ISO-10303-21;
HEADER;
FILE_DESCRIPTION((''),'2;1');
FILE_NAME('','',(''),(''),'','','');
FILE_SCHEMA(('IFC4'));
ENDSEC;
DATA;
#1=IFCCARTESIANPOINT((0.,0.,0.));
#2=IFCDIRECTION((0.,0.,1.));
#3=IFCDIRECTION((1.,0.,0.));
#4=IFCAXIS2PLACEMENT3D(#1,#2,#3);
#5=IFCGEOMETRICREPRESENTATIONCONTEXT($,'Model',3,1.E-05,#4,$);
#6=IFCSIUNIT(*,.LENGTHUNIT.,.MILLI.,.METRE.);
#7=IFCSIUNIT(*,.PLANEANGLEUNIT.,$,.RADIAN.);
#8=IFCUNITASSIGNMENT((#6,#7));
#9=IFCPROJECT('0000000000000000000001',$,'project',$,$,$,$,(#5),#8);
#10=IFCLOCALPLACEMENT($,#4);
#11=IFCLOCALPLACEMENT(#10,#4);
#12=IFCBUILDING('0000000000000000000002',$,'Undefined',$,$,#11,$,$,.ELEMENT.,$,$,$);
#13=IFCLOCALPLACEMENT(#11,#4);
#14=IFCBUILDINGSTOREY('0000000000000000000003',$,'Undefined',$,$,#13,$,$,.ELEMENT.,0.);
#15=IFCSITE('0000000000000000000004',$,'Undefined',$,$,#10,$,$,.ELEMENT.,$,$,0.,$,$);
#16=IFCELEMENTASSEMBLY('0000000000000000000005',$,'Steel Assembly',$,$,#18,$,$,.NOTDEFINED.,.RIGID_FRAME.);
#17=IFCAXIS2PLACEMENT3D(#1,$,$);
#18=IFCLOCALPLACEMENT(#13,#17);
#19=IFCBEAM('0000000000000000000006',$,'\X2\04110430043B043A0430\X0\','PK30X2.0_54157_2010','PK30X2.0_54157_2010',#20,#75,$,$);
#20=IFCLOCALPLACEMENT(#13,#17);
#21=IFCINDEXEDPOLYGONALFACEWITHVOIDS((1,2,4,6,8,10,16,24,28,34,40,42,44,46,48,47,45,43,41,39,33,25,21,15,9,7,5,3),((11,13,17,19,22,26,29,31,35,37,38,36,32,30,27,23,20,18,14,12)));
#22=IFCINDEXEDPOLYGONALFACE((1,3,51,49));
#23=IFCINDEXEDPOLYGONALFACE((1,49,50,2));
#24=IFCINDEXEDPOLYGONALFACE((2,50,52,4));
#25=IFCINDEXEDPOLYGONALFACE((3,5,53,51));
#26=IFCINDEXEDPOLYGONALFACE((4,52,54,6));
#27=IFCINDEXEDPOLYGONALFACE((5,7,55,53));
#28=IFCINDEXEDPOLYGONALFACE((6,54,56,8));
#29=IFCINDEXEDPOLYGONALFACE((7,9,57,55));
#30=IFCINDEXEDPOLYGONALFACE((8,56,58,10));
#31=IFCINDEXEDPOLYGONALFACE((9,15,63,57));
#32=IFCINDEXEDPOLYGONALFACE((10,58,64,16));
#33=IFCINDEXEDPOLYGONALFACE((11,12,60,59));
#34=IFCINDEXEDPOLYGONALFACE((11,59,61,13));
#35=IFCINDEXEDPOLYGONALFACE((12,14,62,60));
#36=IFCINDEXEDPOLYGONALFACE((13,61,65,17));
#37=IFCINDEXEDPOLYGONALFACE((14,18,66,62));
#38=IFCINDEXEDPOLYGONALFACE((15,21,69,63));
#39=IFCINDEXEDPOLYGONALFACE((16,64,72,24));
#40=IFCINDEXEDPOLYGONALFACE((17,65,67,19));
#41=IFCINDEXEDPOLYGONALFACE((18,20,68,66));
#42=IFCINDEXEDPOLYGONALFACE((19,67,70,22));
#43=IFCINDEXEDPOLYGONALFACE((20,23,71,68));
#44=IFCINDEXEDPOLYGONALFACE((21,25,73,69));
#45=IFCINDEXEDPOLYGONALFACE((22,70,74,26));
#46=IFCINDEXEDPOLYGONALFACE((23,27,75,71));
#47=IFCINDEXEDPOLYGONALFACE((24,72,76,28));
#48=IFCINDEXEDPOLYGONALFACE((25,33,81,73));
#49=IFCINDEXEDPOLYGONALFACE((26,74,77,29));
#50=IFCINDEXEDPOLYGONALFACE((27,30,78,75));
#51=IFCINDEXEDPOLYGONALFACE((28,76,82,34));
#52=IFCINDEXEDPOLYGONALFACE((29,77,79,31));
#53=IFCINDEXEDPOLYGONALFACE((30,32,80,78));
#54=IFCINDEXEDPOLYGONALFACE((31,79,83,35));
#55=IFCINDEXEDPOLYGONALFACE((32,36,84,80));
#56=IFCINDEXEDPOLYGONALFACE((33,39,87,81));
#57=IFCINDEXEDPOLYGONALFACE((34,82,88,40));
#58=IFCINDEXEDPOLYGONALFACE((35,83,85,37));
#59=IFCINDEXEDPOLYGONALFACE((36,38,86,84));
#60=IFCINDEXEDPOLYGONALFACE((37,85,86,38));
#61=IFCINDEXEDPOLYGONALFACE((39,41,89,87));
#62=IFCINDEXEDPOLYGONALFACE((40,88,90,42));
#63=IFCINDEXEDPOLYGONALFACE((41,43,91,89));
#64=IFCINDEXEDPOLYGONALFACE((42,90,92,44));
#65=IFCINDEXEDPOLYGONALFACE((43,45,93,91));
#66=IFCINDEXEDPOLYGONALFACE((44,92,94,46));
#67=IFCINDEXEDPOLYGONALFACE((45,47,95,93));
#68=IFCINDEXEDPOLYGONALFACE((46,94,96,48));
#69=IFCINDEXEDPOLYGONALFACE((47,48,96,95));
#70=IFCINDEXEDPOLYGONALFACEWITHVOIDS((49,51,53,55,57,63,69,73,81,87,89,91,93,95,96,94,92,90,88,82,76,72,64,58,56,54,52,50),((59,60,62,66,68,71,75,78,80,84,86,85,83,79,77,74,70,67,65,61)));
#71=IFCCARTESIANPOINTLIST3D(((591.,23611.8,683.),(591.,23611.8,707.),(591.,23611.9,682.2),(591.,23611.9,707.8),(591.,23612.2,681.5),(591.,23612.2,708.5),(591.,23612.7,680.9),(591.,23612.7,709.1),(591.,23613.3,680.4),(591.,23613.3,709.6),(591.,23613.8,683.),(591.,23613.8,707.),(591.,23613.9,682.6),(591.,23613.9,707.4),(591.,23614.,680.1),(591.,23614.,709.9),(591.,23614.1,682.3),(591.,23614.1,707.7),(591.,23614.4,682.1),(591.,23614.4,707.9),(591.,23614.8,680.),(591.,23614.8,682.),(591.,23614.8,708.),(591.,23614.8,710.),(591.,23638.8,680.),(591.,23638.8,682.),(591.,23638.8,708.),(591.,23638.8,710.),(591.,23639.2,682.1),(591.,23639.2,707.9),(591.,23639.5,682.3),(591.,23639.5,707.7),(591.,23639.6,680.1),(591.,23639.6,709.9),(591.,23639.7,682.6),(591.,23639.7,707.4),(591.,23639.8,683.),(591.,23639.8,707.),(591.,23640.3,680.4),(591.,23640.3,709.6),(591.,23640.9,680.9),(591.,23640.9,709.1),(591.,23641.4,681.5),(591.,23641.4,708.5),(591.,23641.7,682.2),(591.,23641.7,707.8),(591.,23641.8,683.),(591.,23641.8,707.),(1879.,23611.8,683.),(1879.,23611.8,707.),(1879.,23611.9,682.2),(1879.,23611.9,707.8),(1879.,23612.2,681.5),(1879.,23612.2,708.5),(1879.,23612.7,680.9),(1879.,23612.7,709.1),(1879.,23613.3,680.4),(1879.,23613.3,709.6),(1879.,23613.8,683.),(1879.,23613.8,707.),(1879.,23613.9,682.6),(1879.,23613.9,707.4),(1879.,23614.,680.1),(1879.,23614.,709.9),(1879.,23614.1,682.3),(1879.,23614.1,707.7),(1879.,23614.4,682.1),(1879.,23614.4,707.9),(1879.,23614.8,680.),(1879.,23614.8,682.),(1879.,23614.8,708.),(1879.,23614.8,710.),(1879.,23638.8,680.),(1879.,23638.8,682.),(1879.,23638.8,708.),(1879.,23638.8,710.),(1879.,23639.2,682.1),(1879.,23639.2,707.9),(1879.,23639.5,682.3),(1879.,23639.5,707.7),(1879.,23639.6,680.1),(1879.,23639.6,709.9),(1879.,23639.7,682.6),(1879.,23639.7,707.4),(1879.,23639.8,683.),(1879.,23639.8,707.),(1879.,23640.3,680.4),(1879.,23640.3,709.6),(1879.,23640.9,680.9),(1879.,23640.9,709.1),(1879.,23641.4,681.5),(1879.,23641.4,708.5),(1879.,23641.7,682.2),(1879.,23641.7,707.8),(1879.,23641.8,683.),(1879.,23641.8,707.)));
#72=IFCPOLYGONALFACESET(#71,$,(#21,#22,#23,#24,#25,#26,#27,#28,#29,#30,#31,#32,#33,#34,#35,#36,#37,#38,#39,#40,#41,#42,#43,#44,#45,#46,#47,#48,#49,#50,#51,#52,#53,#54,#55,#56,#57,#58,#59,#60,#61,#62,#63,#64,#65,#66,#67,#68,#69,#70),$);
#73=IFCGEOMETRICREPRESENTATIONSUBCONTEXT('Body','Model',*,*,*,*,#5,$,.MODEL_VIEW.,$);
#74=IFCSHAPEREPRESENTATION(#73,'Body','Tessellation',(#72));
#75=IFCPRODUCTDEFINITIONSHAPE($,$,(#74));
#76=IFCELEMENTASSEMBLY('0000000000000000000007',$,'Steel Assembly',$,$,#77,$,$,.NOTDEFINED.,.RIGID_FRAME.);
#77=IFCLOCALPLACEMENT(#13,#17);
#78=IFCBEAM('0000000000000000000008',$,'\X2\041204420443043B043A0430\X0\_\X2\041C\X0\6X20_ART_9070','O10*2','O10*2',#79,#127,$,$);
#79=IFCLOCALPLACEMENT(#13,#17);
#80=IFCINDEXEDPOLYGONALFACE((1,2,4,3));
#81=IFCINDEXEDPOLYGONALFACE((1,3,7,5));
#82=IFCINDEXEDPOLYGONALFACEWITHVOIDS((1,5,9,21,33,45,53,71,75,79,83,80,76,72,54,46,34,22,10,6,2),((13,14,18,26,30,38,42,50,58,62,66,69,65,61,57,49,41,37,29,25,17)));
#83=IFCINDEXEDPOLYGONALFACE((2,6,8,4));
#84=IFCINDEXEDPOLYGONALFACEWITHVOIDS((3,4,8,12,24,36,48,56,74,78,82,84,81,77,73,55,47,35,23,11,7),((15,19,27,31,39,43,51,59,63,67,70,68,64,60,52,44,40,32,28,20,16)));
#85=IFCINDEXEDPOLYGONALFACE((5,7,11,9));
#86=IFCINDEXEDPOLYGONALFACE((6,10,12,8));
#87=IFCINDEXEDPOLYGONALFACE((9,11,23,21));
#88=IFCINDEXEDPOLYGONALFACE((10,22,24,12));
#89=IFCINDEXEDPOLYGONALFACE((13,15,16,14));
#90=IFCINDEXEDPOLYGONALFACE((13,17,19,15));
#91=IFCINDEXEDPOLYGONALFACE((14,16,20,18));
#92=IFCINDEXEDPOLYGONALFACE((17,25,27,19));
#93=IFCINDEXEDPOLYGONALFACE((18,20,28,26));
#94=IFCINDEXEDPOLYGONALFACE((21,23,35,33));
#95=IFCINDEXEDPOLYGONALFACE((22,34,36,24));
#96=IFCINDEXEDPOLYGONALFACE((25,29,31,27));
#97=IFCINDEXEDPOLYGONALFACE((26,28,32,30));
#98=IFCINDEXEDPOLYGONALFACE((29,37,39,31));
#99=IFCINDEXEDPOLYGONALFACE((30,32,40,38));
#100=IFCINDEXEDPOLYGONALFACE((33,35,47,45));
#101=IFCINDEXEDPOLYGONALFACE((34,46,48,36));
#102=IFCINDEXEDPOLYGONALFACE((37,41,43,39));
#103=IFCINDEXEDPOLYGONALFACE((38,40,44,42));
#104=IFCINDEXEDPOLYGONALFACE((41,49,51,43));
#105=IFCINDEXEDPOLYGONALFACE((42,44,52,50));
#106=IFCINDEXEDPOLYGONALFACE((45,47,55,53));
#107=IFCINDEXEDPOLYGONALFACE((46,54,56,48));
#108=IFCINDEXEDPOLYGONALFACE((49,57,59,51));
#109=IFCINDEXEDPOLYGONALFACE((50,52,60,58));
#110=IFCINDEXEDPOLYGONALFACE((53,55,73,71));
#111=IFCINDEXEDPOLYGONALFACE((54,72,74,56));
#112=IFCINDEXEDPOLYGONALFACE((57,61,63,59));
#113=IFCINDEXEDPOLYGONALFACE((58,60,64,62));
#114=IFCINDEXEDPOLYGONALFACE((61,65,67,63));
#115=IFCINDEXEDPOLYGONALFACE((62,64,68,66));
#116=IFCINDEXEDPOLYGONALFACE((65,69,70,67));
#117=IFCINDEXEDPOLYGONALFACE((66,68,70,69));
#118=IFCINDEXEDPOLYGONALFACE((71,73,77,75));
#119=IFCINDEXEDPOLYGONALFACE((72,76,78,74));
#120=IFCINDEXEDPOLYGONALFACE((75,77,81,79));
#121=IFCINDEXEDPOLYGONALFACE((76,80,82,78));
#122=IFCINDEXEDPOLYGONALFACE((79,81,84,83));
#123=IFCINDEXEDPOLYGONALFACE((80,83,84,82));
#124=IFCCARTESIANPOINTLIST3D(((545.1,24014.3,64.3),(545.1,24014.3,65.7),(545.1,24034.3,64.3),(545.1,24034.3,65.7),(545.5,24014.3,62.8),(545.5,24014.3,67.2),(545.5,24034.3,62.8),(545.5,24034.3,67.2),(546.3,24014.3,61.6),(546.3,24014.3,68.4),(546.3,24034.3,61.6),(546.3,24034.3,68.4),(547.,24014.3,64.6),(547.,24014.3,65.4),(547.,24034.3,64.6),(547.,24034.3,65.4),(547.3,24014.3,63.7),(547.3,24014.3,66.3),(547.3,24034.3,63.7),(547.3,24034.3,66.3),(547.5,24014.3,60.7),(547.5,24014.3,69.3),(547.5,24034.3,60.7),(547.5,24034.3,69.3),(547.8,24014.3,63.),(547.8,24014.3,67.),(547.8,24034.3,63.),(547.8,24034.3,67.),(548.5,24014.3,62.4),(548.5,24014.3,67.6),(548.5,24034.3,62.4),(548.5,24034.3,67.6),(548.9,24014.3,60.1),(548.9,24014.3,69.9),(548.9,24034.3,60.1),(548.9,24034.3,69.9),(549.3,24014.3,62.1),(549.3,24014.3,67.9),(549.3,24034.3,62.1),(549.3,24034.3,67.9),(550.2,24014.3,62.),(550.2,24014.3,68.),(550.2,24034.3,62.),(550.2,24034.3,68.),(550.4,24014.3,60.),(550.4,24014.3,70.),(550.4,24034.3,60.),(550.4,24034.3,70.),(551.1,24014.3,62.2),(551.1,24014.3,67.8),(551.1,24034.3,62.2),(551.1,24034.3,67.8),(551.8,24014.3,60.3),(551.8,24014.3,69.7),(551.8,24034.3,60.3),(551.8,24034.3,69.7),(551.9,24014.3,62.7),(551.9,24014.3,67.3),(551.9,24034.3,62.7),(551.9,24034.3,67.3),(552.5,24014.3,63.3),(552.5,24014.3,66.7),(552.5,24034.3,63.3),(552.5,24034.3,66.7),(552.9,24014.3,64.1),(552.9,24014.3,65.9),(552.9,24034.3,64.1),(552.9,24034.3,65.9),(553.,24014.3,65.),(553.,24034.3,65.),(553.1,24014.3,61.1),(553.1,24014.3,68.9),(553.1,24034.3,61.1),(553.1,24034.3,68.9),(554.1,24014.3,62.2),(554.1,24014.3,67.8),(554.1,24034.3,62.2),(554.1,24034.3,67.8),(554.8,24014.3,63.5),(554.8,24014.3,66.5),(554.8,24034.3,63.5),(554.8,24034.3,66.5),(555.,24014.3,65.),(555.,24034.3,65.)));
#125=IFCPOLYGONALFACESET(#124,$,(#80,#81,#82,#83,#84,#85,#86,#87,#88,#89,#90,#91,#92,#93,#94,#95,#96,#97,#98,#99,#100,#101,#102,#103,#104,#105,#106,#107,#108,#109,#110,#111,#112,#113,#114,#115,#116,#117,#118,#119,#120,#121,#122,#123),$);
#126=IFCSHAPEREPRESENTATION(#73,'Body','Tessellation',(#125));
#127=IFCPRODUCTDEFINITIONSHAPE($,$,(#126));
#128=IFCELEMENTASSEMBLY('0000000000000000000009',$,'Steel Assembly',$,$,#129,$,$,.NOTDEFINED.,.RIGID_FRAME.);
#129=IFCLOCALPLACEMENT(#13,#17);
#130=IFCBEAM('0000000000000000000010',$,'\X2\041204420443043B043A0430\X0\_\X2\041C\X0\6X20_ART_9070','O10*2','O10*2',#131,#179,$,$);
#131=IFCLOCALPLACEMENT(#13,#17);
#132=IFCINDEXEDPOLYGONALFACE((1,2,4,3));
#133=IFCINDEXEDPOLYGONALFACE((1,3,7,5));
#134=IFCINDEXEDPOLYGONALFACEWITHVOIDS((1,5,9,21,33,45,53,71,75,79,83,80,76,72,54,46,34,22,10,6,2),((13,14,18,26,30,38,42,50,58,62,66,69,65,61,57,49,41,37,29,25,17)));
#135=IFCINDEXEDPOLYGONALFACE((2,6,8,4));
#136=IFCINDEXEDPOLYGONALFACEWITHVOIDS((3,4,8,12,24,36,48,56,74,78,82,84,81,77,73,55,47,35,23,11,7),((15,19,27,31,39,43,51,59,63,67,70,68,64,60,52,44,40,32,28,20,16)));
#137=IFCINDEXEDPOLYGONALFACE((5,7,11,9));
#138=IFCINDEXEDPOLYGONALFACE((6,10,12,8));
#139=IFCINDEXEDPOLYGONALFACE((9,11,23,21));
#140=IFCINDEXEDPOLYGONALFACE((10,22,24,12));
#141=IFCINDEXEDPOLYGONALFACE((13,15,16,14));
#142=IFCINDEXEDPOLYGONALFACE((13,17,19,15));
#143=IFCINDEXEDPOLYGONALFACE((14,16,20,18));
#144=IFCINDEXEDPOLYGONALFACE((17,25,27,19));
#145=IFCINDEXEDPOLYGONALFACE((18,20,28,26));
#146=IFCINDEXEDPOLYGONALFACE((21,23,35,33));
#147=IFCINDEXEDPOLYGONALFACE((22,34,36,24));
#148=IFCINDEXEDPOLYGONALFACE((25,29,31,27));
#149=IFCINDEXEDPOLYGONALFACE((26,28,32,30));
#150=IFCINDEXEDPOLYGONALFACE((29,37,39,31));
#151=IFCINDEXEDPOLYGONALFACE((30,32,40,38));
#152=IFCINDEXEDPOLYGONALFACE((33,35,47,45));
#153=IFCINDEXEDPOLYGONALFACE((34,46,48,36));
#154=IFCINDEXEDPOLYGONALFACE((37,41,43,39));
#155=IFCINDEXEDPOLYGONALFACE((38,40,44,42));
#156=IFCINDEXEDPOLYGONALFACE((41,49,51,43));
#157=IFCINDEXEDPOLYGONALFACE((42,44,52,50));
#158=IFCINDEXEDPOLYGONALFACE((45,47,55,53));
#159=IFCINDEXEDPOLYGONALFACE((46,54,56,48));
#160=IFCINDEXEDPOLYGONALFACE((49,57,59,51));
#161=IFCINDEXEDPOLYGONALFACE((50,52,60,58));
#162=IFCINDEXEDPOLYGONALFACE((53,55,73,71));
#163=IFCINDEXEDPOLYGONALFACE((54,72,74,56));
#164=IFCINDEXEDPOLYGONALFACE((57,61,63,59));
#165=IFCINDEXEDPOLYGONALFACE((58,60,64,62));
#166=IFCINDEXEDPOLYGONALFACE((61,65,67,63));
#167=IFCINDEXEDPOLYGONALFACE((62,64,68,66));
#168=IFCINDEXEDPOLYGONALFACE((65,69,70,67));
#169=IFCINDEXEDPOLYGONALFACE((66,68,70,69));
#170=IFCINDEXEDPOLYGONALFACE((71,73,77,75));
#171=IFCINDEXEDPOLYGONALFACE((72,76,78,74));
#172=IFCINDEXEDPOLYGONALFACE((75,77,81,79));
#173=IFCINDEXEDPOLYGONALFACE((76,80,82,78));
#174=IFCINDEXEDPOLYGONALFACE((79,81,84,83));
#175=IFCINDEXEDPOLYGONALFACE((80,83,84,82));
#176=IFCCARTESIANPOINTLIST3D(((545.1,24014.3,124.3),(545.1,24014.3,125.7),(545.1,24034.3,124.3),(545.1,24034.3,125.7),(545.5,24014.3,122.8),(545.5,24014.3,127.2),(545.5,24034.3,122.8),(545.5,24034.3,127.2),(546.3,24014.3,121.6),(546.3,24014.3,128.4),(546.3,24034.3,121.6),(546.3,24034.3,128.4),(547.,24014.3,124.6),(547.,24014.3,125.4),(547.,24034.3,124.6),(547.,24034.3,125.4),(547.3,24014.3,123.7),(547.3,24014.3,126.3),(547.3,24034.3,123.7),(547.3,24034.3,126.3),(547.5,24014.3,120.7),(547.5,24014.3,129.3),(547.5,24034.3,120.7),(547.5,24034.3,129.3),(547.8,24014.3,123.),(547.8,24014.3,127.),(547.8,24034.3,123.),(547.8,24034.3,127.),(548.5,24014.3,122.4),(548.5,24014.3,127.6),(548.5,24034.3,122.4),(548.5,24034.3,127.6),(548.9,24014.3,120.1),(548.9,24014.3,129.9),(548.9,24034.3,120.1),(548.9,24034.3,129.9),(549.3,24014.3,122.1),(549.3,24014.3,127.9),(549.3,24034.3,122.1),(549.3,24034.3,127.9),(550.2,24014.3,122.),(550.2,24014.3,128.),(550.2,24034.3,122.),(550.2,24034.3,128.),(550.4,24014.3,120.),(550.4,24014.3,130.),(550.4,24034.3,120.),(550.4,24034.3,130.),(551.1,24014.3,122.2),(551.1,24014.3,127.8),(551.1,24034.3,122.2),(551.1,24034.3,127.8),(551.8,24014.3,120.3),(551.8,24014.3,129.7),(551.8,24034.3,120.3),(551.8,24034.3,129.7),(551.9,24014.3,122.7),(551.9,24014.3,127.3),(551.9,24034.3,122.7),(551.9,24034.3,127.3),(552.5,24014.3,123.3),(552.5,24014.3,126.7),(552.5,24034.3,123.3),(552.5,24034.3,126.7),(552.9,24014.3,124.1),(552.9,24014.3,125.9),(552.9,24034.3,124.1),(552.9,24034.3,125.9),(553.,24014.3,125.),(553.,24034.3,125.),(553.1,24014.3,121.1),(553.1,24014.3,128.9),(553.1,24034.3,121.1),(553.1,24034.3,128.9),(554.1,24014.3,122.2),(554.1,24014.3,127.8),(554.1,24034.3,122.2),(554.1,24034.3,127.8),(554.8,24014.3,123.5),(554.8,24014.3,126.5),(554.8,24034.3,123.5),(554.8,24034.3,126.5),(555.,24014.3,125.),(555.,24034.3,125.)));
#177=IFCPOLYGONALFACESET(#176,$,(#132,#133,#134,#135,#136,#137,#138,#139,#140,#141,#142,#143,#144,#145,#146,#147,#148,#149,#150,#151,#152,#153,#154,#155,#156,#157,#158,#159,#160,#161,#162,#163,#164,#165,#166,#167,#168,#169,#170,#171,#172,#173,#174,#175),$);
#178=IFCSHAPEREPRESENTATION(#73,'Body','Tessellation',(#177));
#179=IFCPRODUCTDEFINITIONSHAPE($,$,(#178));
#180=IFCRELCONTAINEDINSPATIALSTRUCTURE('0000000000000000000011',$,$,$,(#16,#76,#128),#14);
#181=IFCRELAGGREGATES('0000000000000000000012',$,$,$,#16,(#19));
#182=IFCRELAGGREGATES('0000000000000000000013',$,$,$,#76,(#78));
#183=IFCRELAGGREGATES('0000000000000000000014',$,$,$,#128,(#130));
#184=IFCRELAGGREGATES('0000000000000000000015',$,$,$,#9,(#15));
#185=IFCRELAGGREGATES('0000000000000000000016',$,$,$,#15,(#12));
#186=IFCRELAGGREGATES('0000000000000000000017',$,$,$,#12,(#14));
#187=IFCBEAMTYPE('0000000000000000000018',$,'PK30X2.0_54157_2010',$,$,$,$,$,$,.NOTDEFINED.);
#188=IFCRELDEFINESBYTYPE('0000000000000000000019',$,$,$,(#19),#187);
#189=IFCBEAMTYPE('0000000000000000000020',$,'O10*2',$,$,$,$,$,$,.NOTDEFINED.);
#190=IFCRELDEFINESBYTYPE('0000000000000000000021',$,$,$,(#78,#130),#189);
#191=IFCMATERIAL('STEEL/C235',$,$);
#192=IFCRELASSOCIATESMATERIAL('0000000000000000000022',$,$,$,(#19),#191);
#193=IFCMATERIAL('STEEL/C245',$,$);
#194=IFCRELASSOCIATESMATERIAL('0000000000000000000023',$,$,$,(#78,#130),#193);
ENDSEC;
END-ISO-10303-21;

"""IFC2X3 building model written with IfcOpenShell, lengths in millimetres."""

from ifc_helpers import new_model, si_unit, frame, origin_with_axes, origin_2d_with_axis, place, context, subcontext, project, spatial, hollow_rectangle, hollow_circle, extrude, material, type_object, element, aggregate, save


model = new_model("IFC2X3")

# Units and contexts
model_context = context("Model", 3, precision=1e-05, world=origin_with_axes())
body_context = subcontext(model_context, "Body", "Model", "MODEL_VIEW")
ifc_project = project(units=[si_unit("LENGTHUNIT", "METRE", prefix="MILLI"), si_unit("PLANEANGLEUNIT", "RADIAN")], contexts=[model_context])

# Site, building, storey
site_placement = place(None, origin_with_axes())
site = spatial("IfcSite", under=ifc_project, at=site_placement, Name="Undefined", CompositionType="ELEMENT", RefElevation=0.0)
building_placement = place(site_placement, origin_with_axes())
building = spatial("IfcBuilding", under=site, at=building_placement, Name="Undefined", CompositionType="ELEMENT")
storey_placement = place(building_placement, origin_with_axes())
storey = spatial("IfcBuildingStorey", under=building, at=storey_placement, Name="Undefined", CompositionType="ELEMENT", Elevation=0.0)

# Element assemblies, beams
ifc_material_1 = material(Name="STEEL/C235")
ifc_material_2 = material(Name="STEEL/C245")
beam_type_1 = type_object("IfcBeamType", Name="PK30X2.0_54157_2010", PredefinedType="NOTDEFINED")
assembly_1_placement = place(storey_placement, origin_with_axes())
assembly_1 = element("IfcElementAssembly", 1, at=assembly_1_placement, inside=storey, Name="Steel Assembly", AssemblyPlace="NOTDEFINED", PredefinedType="RIGID_FRAME")
beam_1_placement = place(assembly_1_placement, frame((591.0, 23626.8, 695.0), z_axis=(0.0, -1.0, 0.0), x_axis=(1.0, 0.0, 0.0)))
beam_1 = element("IfcBeam", 2, at=beam_1_placement, type_object=beam_type_1, material=ifc_material_1, Name="Балка", Description="PK30X2.0_54157_2010", ObjectType="PK30X2.0_54157_2010", context=body_context, shape_type="SweptSolid", body=[
    extrude(hollow_rectangle(XDim=30.0, YDim=30.0, WallThickness=2.0, InnerFilletRadius=1.0, OuterFilletRadius=3.0, at=origin_2d_with_axis()), frame((1288.0, 0.0, 0.0), z_axis=(-1.0, 0.0, 0.0), x_axis=(0.0, -1.0, 0.0)), (0.0, 0.0, 1.0), 1288.0),
])
aggregate(assembly_1, [beam_1])
assembly_2_placement = place(storey_placement, origin_with_axes())
assembly_2 = element("IfcElementAssembly", 3, at=assembly_2_placement, inside=storey, Name="Steel Assembly", AssemblyPlace="NOTDEFINED", PredefinedType="RIGID_FRAME")
beam_type_2 = type_object("IfcBeamType", Name="O10*2", PredefinedType="NOTDEFINED")
beam_2_placement = place(assembly_2_placement, frame((550.0, 24014.3, 65.0), z_axis=(0.0, 0.0, 1.0), x_axis=(0.0, 1.0, 0.0)))
beam_2 = element("IfcBeam", 4, at=beam_2_placement, type_object=beam_type_2, material=ifc_material_2, Name="Втулка_М6X20_ART_9070", Description="O10*2", ObjectType="O10*2", context=body_context, shape_type="SweptSolid", body=[
    extrude(hollow_circle(Radius=5.0, WallThickness=2.0, at=origin_2d_with_axis()), frame((20.0, 0.0, 0.0), z_axis=(-1.0, 0.0, 0.0), x_axis=(0.0, -1.0, 0.0)), (0.0, 0.0, 1.0), 20.0),
])
aggregate(assembly_2, [beam_2])
assembly_3_placement = place(storey_placement, origin_with_axes())
assembly_3 = element("IfcElementAssembly", 5, at=assembly_3_placement, inside=storey, Name="Steel Assembly", AssemblyPlace="NOTDEFINED", PredefinedType="RIGID_FRAME")
beam_3_placement = place(assembly_3_placement, frame((550.0, 24014.3, 125.0), z_axis=(0.0, 0.0, 1.0), x_axis=(0.0, 1.0, 0.0)))
beam_3 = element("IfcBeam", 6, at=beam_3_placement, type_object=beam_type_2, material=ifc_material_2, Name="Втулка_М6X20_ART_9070", Description="O10*2", ObjectType="O10*2", context=body_context, shape_type="SweptSolid", body=[
    extrude(hollow_circle(Radius=5.0, WallThickness=2.0, at=origin_2d_with_axis()), frame((20.0, 0.0, 0.0), z_axis=(-1.0, 0.0, 0.0), x_axis=(0.0, -1.0, 0.0)), (0.0, 0.0, 1.0), 20.0),
])
aggregate(assembly_3, [beam_3])

save(model, "model.ifc")
